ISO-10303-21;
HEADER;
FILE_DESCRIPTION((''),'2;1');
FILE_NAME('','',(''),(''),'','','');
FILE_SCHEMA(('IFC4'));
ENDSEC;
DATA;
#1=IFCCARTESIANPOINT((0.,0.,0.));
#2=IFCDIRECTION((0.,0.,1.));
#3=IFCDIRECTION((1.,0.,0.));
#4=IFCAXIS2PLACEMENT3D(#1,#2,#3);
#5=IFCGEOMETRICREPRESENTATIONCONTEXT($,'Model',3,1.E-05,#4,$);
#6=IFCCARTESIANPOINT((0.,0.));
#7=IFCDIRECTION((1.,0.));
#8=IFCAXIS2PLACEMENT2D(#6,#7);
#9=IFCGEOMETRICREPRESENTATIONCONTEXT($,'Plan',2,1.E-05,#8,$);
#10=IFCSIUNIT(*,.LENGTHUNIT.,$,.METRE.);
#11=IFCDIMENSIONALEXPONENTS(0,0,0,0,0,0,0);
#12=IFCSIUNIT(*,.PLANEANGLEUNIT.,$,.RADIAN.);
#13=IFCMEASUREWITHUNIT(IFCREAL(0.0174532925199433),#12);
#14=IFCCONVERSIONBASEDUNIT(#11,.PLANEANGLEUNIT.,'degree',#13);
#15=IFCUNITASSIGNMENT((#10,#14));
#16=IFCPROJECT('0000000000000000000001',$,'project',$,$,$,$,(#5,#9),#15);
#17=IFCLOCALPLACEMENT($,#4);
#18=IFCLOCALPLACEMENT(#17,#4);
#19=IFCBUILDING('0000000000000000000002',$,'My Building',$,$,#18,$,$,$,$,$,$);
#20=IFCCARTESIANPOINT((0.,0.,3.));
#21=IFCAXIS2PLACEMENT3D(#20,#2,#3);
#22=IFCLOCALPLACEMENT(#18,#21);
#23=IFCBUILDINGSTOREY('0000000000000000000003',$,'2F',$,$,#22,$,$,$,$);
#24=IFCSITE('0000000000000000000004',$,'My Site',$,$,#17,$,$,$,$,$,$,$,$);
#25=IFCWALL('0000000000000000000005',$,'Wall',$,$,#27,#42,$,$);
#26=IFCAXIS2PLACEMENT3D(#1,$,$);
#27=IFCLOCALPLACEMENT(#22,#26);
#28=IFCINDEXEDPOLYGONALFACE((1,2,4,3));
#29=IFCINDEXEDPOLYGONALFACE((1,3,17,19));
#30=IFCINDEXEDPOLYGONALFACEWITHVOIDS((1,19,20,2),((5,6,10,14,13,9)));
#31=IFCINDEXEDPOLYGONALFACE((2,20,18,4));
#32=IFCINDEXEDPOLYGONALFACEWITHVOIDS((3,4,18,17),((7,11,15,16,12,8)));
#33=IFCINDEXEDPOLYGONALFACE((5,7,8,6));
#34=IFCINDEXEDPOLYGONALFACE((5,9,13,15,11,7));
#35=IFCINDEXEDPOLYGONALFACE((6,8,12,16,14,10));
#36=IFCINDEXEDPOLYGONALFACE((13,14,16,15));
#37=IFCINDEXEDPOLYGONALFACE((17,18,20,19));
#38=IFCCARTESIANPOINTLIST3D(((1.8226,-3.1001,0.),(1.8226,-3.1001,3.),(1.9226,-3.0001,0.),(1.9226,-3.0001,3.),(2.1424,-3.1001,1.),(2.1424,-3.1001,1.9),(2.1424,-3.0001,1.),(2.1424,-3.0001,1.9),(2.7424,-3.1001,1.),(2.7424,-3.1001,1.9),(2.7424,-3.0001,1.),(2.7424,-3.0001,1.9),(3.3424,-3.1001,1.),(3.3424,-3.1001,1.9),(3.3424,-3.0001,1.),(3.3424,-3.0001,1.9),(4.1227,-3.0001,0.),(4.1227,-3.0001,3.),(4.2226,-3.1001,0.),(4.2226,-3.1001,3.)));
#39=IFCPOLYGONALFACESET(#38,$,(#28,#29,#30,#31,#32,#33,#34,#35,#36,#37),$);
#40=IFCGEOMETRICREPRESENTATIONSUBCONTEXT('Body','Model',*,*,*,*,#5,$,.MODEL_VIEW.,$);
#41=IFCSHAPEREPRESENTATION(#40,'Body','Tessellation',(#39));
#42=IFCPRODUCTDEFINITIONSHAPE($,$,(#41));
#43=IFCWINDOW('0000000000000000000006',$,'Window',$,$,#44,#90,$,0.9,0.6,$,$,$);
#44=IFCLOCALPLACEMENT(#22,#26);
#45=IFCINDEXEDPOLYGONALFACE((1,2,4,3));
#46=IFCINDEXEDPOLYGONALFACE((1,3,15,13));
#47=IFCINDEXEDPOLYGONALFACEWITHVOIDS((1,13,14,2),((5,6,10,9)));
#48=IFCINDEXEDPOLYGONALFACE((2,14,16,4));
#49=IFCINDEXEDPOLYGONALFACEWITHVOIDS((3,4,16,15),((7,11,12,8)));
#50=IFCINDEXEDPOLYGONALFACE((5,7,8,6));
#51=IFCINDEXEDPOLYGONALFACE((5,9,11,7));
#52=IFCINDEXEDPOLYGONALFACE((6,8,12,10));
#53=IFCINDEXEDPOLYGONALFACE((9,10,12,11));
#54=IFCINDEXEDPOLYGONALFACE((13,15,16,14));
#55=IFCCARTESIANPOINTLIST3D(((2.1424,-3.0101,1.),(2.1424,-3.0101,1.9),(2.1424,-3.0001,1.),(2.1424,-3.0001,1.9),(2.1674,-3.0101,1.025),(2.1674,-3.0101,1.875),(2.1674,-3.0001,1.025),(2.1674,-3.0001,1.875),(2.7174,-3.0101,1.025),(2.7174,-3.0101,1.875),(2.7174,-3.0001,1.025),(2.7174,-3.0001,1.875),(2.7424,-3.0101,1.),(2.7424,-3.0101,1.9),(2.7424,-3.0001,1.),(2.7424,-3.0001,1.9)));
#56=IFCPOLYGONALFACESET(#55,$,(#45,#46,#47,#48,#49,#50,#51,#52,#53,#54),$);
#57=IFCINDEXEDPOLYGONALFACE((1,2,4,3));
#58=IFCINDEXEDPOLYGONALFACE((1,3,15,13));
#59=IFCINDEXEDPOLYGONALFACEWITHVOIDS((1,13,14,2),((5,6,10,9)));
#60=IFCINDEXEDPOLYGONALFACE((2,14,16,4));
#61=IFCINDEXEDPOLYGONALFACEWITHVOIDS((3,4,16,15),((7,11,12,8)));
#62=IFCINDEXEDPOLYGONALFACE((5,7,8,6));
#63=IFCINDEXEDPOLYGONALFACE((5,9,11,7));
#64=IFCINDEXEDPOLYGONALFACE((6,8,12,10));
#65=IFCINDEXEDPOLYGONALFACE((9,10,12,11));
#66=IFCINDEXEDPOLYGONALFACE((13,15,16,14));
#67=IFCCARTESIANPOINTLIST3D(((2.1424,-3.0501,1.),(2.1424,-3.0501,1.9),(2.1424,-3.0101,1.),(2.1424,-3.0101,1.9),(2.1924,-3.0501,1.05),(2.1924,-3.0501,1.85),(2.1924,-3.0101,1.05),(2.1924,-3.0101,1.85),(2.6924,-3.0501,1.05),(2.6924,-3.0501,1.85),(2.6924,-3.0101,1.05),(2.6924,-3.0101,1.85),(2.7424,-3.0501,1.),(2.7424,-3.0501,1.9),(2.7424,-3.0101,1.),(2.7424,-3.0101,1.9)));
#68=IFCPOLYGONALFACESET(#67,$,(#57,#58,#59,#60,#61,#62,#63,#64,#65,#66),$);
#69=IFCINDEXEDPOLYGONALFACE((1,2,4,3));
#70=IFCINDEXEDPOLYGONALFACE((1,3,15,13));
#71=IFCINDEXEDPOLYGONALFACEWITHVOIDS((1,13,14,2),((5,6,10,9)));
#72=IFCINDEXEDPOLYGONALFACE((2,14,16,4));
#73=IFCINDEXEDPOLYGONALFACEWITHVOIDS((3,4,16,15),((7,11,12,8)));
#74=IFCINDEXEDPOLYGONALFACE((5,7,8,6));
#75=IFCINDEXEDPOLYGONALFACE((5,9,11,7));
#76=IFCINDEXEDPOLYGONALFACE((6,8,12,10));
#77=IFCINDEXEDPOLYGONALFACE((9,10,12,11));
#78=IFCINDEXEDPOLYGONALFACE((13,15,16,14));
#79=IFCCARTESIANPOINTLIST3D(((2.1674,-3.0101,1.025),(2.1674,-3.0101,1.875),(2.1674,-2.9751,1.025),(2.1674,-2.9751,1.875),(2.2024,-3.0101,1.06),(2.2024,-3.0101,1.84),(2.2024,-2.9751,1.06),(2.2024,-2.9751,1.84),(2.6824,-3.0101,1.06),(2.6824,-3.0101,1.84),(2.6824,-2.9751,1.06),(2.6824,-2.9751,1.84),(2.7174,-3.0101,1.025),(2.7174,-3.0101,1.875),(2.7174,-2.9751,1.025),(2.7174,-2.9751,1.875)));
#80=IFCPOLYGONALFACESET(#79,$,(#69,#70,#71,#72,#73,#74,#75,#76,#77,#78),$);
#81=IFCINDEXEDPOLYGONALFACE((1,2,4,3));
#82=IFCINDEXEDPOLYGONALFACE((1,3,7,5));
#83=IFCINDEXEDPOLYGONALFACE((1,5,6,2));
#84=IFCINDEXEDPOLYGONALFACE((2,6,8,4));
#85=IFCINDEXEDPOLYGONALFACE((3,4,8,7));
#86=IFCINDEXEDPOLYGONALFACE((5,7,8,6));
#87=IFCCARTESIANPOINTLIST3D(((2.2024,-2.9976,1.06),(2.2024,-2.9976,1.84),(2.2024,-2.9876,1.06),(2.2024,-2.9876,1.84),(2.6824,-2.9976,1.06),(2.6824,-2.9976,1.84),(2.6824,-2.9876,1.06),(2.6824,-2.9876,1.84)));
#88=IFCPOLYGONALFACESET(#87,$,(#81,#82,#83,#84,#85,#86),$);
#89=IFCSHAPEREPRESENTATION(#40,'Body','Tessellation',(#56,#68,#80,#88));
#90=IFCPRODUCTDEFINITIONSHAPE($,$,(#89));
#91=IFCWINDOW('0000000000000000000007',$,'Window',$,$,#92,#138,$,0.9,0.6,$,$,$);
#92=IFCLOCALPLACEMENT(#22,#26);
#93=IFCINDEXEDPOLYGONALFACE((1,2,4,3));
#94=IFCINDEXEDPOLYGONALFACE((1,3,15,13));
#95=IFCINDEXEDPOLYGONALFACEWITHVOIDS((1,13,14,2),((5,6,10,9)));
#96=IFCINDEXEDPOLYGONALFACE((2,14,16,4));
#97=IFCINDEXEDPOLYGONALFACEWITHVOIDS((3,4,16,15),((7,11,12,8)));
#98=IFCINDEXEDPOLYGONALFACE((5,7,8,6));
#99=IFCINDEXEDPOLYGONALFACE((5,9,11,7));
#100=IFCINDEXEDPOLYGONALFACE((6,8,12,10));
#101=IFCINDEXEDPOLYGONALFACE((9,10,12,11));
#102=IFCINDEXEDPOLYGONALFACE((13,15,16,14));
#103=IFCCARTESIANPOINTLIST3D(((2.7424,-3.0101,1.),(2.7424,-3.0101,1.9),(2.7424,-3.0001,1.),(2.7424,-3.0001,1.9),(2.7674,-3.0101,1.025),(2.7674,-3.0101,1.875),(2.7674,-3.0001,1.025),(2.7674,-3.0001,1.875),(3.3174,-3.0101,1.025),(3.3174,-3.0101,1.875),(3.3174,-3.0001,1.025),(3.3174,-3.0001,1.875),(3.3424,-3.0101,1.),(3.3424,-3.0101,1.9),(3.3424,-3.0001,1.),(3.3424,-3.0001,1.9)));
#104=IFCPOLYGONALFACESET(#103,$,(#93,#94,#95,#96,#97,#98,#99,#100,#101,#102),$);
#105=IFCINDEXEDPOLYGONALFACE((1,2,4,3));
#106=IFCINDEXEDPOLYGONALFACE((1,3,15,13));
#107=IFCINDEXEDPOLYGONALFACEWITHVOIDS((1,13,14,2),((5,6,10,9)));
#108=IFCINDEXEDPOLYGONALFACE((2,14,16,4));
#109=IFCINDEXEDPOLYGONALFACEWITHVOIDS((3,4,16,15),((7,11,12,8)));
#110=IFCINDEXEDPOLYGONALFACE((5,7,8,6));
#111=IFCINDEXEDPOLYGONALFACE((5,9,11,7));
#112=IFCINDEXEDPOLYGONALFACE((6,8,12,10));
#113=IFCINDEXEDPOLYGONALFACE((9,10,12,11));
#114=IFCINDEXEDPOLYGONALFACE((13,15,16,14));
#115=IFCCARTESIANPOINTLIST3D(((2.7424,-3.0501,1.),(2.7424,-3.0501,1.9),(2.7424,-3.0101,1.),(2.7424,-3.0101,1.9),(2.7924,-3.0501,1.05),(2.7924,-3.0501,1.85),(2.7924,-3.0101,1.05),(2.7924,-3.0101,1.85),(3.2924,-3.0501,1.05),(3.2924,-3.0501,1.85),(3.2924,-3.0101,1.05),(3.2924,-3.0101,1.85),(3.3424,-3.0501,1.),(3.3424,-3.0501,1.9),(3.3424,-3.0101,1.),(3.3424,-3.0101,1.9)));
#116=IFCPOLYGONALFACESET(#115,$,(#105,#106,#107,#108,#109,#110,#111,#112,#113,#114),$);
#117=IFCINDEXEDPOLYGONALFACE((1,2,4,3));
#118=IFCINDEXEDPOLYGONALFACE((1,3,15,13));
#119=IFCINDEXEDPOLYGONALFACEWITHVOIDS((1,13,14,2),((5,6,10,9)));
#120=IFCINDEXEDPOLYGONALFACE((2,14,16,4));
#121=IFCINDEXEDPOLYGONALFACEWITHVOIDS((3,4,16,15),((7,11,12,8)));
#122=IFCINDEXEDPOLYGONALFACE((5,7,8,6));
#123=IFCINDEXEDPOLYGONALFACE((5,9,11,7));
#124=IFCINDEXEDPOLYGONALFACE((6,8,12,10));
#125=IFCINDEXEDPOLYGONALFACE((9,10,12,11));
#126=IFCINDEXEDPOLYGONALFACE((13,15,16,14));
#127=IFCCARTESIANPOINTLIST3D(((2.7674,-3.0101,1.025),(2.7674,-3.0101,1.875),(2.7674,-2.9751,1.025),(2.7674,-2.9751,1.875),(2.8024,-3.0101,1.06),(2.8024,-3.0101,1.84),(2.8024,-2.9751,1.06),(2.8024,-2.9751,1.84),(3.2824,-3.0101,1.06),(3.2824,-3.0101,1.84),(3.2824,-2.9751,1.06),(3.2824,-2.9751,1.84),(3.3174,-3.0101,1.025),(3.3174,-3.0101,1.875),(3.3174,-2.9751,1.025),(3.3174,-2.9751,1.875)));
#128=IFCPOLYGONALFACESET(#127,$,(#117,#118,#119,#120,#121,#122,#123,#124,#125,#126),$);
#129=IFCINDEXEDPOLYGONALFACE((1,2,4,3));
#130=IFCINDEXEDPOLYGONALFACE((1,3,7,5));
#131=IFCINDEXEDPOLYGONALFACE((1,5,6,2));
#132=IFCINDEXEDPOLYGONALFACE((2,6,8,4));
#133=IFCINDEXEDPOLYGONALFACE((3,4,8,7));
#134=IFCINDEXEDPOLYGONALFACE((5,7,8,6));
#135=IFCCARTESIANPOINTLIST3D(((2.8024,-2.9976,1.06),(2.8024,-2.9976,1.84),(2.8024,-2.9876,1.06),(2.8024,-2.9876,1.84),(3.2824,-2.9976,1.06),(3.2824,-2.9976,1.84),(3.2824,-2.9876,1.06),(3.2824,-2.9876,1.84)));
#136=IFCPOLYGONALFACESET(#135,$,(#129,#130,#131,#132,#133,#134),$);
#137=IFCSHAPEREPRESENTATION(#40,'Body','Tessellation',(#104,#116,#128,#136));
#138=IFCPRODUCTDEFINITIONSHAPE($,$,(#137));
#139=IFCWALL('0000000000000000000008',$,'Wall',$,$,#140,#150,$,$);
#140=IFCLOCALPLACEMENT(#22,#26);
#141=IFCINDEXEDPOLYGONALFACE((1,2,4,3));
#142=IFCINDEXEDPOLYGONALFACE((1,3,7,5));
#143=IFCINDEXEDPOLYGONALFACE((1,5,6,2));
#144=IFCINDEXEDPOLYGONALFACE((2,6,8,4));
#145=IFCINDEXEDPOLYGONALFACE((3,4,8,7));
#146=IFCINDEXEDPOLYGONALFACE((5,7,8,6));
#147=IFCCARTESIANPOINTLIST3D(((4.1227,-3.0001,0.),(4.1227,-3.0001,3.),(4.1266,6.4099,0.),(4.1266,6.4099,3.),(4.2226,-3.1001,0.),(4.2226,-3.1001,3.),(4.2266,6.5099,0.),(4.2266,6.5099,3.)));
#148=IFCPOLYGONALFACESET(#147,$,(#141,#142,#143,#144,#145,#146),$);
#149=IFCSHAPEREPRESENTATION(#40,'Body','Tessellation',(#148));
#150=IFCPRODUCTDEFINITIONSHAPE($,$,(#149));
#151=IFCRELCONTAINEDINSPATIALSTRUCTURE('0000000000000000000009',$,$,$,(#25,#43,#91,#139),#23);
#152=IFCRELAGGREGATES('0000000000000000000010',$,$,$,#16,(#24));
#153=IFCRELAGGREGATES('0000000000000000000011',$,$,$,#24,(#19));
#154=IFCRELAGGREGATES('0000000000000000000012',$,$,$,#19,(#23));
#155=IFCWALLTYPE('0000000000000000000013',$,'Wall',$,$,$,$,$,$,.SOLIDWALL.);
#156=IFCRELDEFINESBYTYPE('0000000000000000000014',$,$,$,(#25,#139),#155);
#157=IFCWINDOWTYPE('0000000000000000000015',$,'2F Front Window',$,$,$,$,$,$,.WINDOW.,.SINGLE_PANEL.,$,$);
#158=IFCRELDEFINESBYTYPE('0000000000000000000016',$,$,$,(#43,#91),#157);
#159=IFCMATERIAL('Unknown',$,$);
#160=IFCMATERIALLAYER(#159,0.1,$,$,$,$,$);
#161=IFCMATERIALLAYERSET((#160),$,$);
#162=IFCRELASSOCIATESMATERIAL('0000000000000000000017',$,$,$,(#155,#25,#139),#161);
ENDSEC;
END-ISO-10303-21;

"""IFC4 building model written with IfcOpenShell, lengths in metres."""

from ifc_helpers import new_model, entity, si_unit, converted_unit, frame, origin_with_axes, origin_2d_with_axis, place, context, subcontext, project, spatial, line, indexed_curve, outline, extrude, shape, source, transform, mapped, material, layer, layer_set, layer_usage, type_object, type_shapes, element, fill, save


model = new_model("IFC4")

# Units and contexts
model_context = context("Model", 3, precision=1e-05, world=origin_with_axes())
plan_context = context("Plan", 2, precision=1e-05, world=origin_2d_with_axis())
body_context_1 = subcontext(model_context, "Body", "Model", "MODEL_VIEW")
body_context_2 = subcontext(plan_context, "Body", "Plan", "PLAN_VIEW")
ifc_project = project(units=[si_unit("LENGTHUNIT", "METRE"), converted_unit("PLANEANGLEUNIT", "degree", entity("IfcReal", 0.0174532925199433), si_unit("PLANEANGLEUNIT", "RADIAN"), dimensions=[0, 0, 0, 0, 0, 0, 0])], contexts=[model_context, plan_context])

# Site, building, storey
site_placement = place(None, origin_with_axes())
site = spatial("IfcSite", under=ifc_project, at=site_placement, Name="My Site")
building_placement = place(site_placement, origin_with_axes())
building = spatial("IfcBuilding", under=site, at=building_placement, Name="My Building")
storey_placement = place(building_placement, frame((0.0, 0.0, 3.0), z_axis=(0.0, 0.0, 1.0), x_axis=(1.0, 0.0, 0.0)))
storey = spatial("IfcBuildingStorey", under=building, at=storey_placement, Name="2F")

# Shared definitions
ifc_material = material(Name="Unknown")

# Wall, openings, windows
ifc_layer_1 = layer(ifc_material, 0.1)
ifc_layer_set_1 = layer_set([ifc_layer_1])
ifc_layer_usage_1 = layer_usage(ifc_layer_set_1, "AXIS2", "POSITIVE", 0.0)
wall_type = type_object("IfcWallType", Name="Wall", PredefinedType="SOLIDWALL", material=ifc_layer_set_1)
wall_1_placement = place(storey_placement, frame((1.8226, -3.1001, 0.0), z_axis=(0.0, 0.0, 1.0), x_axis=(1.0, 0.0, 0.0)))
wall_1 = element("IfcWall", 1, at=wall_1_placement, inside=storey, type_object=wall_type, material=ifc_layer_usage_1, Name="Wall", context=body_context_1, shape_type="SweptSolid", body=[
    extrude(outline(indexed_curve([(0.0, 0.0), (0.1, 0.1), (2.3, 0.1), (2.4, 0.0)], segments=[line(1, 2, 3, 4, 1)])), origin_with_axes(), (0.0, 0.0, 1.0), 3.0),
])
shared_shape_1 = source(origin_with_axes(), body_context_1, "Body", "SweptSolid", [
    extrude(outline(indexed_curve([(0.0, 0.0), (0.6, 0.0), (0.6, 0.9), (0.0, 0.9)], segments=[line(1, 2, 3, 4, 1)])), frame((0.0, -0.6, 0.0), z_axis=(0.0, -1.0, 0.0), x_axis=(1.0, 0.0, 0.0)), (0.0, 0.0, -1.0), 1.2),
])
opening_1_placement = place(wall_1_placement, frame((0.3197, 0.0, 1.0), z_axis=(0.0, 0.0, 1.0), x_axis=(1.0, 0.0, 0.0)))
opening_1 = element("IfcOpeningElement", 2, at=opening_1_placement, cuts=wall_1, PredefinedType="OPENING", context=body_context_1, shape_type="MappedRepresentation", body=[
    mapped(shared_shape_1, transform((0.0, 0.0, 0.0), x_axis=(1.0, 0.0, 0.0), y_axis=(0.0, 1.0, 0.0), z_axis=(0.0, 0.0, 1.0), scale=1.0)),
])
opening_2_placement = place(wall_1_placement, frame((0.9197, 0.0, 1.0), z_axis=(0.0, 0.0, 1.0), x_axis=(1.0, 0.0, 0.0)))
opening_2 = element("IfcOpeningElement", 3, at=opening_2_placement, cuts=wall_1, PredefinedType="OPENING", context=body_context_1, shape_type="MappedRepresentation", body=[
    mapped(shared_shape_1, transform((0.0, 0.0, 0.0), x_axis=(1.0, 0.0, 0.0), y_axis=(0.0, 1.0, 0.0), z_axis=(0.0, 0.0, 1.0), scale=1.0)),
])
window_type = type_object("IfcWindowType", Name="2F Front Window", PartitioningType="SINGLE_PANEL", PredefinedType="WINDOW")
shared_shape_2 = source(origin_with_axes(), body_context_1, "Body", "SweptSolid", [
    extrude(outline(indexed_curve([(0.0, 0.0), (0.6, 0.0), (0.6, 0.9), (0.0, 0.9)], segments=[line(1, 2, 3, 4, 1)]), holes=[indexed_curve([(0.025, 0.025), (0.575, 0.025), (0.575, 0.875), (0.025, 0.875)], segments=[line(1, 2, 3, 4, 1)])]), frame((0.0, 0.09, 0.0), z_axis=(0.0, -1.0, 0.0), x_axis=(1.0, 0.0, 0.0)), (0.0, 0.0, -1.0), 0.01),
    extrude(outline(indexed_curve([(0.0, 0.0), (0.6, 0.0), (0.6, 0.9), (0.0, 0.9)], segments=[line(1, 2, 3, 4, 1)]), holes=[indexed_curve([(0.05, 0.05), (0.55, 0.05), (0.55, 0.85), (0.05, 0.85)], segments=[line(1, 2, 3, 4, 1)])]), frame((0.0, 0.05, 0.0), z_axis=(0.0, -1.0, 0.0), x_axis=(1.0, 0.0, 0.0)), (0.0, 0.0, -1.0), 0.04),
    extrude(outline(indexed_curve([(0.0, 0.0), (0.55, 0.0), (0.55, 0.85), (0.0, 0.85)], segments=[line(1, 2, 3, 4, 1)]), holes=[indexed_curve([(0.035, 0.035), (0.515, 0.035), (0.515, 0.815), (0.035, 0.815)], segments=[line(1, 2, 3, 4, 1)])]), frame((0.025, 0.09, 0.025), z_axis=(0.0, -1.0, 0.0), x_axis=(1.0, 0.0, 0.0)), (0.0, 0.0, -1.0), 0.035),
    extrude(outline(indexed_curve([(0.035, 0.035), (0.515, 0.035), (0.515, 0.815), (0.035, 0.815)], segments=[line(1, 2, 3, 4, 1)])), frame((0.025, 0.1025, 0.025), z_axis=(0.0, -1.0, 0.0), x_axis=(1.0, 0.0, 0.0)), (0.0, 0.0, -1.0), 0.01),
])
shared_shape_3 = source(origin_with_axes(), body_context_2, "Body", "Curve2D", [
    entity("IfcIndexedPolyCurve", entity("IfcCartesianPointList2D", [[0.05, 0.05], [0.55, 0.05]])),
    entity("IfcIndexedPolyCurve", entity("IfcCartesianPointList2D", [[0.0, 0.1], [0.025, 0.1], [0.025, 0.09], [0.05, 0.09], [0.05, 0.05], [0.0, 0.05]]), [entity("IfcLineIndex", [1, 2, 3, 4, 5, 6, 1])]),
    entity("IfcIndexedPolyCurve", entity("IfcCartesianPointList2D", [[0.6, 0.1], [0.575, 0.1], [0.575, 0.09], [0.55, 0.09], [0.55, 0.05], [0.6, 0.05]]), [entity("IfcLineIndex", [1, 2, 3, 4, 5, 6, 1])]),
    entity("IfcIndexedPolyCurve", entity("IfcCartesianPointList2D", [[0.025, 0.09], [0.06, 0.09], [0.06, 0.125], [0.025, 0.125]]), [entity("IfcLineIndex", [1, 2, 3, 4, 1])]),
    entity("IfcIndexedPolyCurve", entity("IfcCartesianPointList2D", [[0.575, 0.09], [0.54, 0.09], [0.54, 0.125], [0.575, 0.125]]), [entity("IfcLineIndex", [1, 2, 3, 4, 1])]),
    entity("IfcIndexedPolyCurve", entity("IfcCartesianPointList2D", [[0.06, 0.09], [0.54, 0.09]])),
    entity("IfcIndexedPolyCurve", entity("IfcCartesianPointList2D", [[0.06, 0.125], [0.54, 0.125]])),
    entity("IfcIndexedPolyCurve", entity("IfcCartesianPointList2D", [[0.06, 0.1075], [0.54, 0.1075]])),
])
type_shapes(window_type, [shared_shape_2, shared_shape_3])
window_1_placement = place(opening_1_placement, origin_with_axes())
window_1 = element("IfcWindow", 4, at=window_1_placement, inside=storey, type_object=window_type, Name="Window", OverallHeight=0.9, OverallWidth=0.6, shapes=[
    shape(body_context_1, "Body", "MappedRepresentation", [mapped(shared_shape_2, transform((0.0, 0.0, 0.0), x_axis=(1.0, 0.0, 0.0), y_axis=(0.0, 1.0, 0.0), z_axis=(0.0, 0.0, 1.0), scale=1.0))]),
    shape(body_context_2, "Body", "MappedRepresentation", [mapped(shared_shape_3, transform((0.0, 0.0, 0.0), x_axis=(1.0, 0.0, 0.0), y_axis=(0.0, 1.0, 0.0), z_axis=(0.0, 0.0, 1.0), scale=1.0))]),
])
fill(opening_1, window_1)
window_2_placement = place(opening_2_placement, origin_with_axes())
window_2 = element("IfcWindow", 5, at=window_2_placement, inside=storey, type_object=window_type, Name="Window", OverallHeight=0.9, OverallWidth=0.6, shapes=[
    shape(body_context_1, "Body", "MappedRepresentation", [mapped(shared_shape_2, transform((0.0, 0.0, 0.0), x_axis=(1.0, 0.0, 0.0), y_axis=(0.0, 1.0, 0.0), z_axis=(0.0, 0.0, 1.0), scale=1.0))]),
    shape(body_context_2, "Body", "MappedRepresentation", [mapped(shared_shape_3, transform((0.0, 0.0, 0.0), x_axis=(1.0, 0.0, 0.0), y_axis=(0.0, 1.0, 0.0), z_axis=(0.0, 0.0, 1.0), scale=1.0))]),
])
fill(opening_2, window_2)

# Wall
ifc_layer_usage_2 = layer_usage(ifc_layer_set_1, "AXIS2", "POSITIVE", 0.0)
wall_2_placement = place(storey_placement, frame((4.2226, -3.1001, 0.0), z_axis=(0.0, 0.0, 1.0), x_axis=(0.000415, 1.0, 0.0)))
element("IfcWall", 6, at=wall_2_placement, inside=storey, type_object=wall_type, material=ifc_layer_usage_2, Name="Wall", context=body_context_1, shape_type="SweptSolid", body=[
    extrude(outline(indexed_curve([(0.0, 0.0), (0.1, 0.1), (9.51, 0.1), (9.61, 0.0)], segments=[line(1, 2, 3, 4, 1)])), origin_with_axes(), (0.0, 0.0, 1.0), 3.0),
])

save(model, "model.ifc")
